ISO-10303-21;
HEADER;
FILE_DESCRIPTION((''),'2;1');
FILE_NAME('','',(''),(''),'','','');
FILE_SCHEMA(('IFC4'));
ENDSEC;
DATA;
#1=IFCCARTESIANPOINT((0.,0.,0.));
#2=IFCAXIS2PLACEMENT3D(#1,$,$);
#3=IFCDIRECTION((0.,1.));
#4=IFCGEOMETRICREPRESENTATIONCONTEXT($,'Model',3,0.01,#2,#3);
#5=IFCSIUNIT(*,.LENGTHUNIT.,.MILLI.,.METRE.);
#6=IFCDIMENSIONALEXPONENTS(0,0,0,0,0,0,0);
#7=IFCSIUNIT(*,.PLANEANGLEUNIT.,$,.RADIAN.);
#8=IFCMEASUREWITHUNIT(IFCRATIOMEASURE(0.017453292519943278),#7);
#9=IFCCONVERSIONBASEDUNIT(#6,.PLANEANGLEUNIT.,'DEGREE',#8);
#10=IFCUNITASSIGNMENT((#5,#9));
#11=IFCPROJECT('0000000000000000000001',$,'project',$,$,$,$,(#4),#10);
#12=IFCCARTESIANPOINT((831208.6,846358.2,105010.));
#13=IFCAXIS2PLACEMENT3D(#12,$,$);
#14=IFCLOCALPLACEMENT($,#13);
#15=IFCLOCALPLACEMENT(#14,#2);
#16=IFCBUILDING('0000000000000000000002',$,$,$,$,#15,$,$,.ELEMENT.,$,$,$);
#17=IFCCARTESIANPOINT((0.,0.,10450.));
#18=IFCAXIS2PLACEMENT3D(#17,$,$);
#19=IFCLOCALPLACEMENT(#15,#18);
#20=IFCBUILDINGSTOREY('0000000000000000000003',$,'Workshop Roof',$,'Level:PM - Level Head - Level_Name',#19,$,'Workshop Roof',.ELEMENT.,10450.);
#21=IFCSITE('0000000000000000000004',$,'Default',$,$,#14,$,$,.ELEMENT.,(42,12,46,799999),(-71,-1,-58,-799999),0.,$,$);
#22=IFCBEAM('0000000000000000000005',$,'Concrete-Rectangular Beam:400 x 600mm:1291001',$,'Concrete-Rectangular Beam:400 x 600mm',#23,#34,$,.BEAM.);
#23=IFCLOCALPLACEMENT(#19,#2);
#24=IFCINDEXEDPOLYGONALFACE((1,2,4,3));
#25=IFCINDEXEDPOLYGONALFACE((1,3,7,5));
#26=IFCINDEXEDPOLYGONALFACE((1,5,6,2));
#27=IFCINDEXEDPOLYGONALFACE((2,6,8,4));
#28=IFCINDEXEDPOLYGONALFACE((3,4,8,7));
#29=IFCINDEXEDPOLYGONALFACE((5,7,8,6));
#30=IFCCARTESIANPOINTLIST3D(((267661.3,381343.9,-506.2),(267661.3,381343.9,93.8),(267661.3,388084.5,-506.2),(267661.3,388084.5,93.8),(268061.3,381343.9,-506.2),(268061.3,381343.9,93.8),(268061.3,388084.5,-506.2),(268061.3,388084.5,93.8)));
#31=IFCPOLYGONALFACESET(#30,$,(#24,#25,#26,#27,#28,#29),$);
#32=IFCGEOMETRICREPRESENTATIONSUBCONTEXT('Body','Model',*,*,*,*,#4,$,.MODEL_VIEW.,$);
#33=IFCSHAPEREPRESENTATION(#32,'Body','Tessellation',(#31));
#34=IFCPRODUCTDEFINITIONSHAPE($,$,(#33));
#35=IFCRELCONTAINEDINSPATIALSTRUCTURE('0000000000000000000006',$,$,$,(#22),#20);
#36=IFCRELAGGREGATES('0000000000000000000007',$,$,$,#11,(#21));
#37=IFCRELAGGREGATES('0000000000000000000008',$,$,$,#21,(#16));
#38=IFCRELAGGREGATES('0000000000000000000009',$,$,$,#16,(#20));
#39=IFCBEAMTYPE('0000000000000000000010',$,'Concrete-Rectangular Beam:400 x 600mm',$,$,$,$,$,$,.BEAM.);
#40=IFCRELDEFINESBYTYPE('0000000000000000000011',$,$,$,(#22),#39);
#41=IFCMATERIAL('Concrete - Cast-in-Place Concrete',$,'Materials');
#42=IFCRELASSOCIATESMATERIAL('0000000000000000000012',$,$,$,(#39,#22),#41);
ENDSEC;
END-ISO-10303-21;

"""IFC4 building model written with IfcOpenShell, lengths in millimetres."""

from ifc_helpers import new_model, entity, si_unit, converted_unit, direction, frame, origin, place, context, subcontext, project, spatial, indexed_curve, outline, extrude, source, transform, mapped, material, type_object, type_shapes, element, save


model = new_model("IFC4")

# Units and contexts
model_context = context("Model", 3, precision=0.01, world=origin(), true_north=direction((0.0, 1.0)))
body_context = subcontext(model_context, "Body", "Model", "MODEL_VIEW")
ifc_project = project(units=[si_unit("LENGTHUNIT", "METRE", prefix="MILLI"), converted_unit("PLANEANGLEUNIT", "DEGREE", entity("IfcRatioMeasure", 0.017453292519943278), si_unit("PLANEANGLEUNIT", "RADIAN"), dimensions=[0, 0, 0, 0, 0, 0, 0])], contexts=[model_context])

# Site, building, storey
site_placement = place(None, frame((831208.6, 846358.2, 105010.0)))
site = spatial("IfcSite", under=ifc_project, at=site_placement, Name="Default", CompositionType="ELEMENT", RefLatitude=(42, 12, 46, 799999), RefLongitude=(-71, -1, -58, -799999), RefElevation=0.0)
building_placement = place(site_placement, origin())
building = spatial("IfcBuilding", under=site, at=building_placement, CompositionType="ELEMENT")
storey_placement = place(building_placement, frame((0.0, 0.0, 10450.0)))
storey = spatial("IfcBuildingStorey", under=building, at=storey_placement, Name="Workshop Roof", ObjectType="Level:PM - Level Head - Level_Name", LongName="Workshop Roof", CompositionType="ELEMENT", Elevation=10450.0)

# Beam
ifc_material = material(Name="Concrete - Cast-in-Place Concrete", Category="Materials")
beam_type_1 = type_object("IfcBeamType", Name="Concrete-Rectangular Beam:400 x 600mm", PredefinedType="BEAM", material=ifc_material)
shared_shape_1 = source(origin(), body_context, "Body", "SweptSolid", [
    extrude(outline(indexed_curve([(-200.0, -300.0), (200.0, -300.0), (200.0, 300.0), (-200.0, 300.0), (-200.0, -300.0)], self_intersect=False)), frame((267861.3, 388084.5, 10243.8), z_axis=(0.0, -1.0, 0.0), x_axis=(-1.0, 0.0, 0.0)), (0.0, 0.0, 1.0), 6740.6),
])
type_shapes(beam_type_1, [shared_shape_1])
beam_1_placement = place(storey_placement, frame((0.0, 0.0, -10450.0)))
element("IfcBeam", 1, at=beam_1_placement, inside=storey, type_object=beam_type_1, material=ifc_material, Name="Concrete-Rectangular Beam:400 x 600mm:1291001", ObjectType="Concrete-Rectangular Beam:400 x 600mm", PredefinedType="BEAM", context=body_context, shape_type="MappedRepresentation", body=[
    mapped(shared_shape_1, transform((0.0, 0.0, 0.0), scale=1.0)),
])

save(model, "model.ifc")
